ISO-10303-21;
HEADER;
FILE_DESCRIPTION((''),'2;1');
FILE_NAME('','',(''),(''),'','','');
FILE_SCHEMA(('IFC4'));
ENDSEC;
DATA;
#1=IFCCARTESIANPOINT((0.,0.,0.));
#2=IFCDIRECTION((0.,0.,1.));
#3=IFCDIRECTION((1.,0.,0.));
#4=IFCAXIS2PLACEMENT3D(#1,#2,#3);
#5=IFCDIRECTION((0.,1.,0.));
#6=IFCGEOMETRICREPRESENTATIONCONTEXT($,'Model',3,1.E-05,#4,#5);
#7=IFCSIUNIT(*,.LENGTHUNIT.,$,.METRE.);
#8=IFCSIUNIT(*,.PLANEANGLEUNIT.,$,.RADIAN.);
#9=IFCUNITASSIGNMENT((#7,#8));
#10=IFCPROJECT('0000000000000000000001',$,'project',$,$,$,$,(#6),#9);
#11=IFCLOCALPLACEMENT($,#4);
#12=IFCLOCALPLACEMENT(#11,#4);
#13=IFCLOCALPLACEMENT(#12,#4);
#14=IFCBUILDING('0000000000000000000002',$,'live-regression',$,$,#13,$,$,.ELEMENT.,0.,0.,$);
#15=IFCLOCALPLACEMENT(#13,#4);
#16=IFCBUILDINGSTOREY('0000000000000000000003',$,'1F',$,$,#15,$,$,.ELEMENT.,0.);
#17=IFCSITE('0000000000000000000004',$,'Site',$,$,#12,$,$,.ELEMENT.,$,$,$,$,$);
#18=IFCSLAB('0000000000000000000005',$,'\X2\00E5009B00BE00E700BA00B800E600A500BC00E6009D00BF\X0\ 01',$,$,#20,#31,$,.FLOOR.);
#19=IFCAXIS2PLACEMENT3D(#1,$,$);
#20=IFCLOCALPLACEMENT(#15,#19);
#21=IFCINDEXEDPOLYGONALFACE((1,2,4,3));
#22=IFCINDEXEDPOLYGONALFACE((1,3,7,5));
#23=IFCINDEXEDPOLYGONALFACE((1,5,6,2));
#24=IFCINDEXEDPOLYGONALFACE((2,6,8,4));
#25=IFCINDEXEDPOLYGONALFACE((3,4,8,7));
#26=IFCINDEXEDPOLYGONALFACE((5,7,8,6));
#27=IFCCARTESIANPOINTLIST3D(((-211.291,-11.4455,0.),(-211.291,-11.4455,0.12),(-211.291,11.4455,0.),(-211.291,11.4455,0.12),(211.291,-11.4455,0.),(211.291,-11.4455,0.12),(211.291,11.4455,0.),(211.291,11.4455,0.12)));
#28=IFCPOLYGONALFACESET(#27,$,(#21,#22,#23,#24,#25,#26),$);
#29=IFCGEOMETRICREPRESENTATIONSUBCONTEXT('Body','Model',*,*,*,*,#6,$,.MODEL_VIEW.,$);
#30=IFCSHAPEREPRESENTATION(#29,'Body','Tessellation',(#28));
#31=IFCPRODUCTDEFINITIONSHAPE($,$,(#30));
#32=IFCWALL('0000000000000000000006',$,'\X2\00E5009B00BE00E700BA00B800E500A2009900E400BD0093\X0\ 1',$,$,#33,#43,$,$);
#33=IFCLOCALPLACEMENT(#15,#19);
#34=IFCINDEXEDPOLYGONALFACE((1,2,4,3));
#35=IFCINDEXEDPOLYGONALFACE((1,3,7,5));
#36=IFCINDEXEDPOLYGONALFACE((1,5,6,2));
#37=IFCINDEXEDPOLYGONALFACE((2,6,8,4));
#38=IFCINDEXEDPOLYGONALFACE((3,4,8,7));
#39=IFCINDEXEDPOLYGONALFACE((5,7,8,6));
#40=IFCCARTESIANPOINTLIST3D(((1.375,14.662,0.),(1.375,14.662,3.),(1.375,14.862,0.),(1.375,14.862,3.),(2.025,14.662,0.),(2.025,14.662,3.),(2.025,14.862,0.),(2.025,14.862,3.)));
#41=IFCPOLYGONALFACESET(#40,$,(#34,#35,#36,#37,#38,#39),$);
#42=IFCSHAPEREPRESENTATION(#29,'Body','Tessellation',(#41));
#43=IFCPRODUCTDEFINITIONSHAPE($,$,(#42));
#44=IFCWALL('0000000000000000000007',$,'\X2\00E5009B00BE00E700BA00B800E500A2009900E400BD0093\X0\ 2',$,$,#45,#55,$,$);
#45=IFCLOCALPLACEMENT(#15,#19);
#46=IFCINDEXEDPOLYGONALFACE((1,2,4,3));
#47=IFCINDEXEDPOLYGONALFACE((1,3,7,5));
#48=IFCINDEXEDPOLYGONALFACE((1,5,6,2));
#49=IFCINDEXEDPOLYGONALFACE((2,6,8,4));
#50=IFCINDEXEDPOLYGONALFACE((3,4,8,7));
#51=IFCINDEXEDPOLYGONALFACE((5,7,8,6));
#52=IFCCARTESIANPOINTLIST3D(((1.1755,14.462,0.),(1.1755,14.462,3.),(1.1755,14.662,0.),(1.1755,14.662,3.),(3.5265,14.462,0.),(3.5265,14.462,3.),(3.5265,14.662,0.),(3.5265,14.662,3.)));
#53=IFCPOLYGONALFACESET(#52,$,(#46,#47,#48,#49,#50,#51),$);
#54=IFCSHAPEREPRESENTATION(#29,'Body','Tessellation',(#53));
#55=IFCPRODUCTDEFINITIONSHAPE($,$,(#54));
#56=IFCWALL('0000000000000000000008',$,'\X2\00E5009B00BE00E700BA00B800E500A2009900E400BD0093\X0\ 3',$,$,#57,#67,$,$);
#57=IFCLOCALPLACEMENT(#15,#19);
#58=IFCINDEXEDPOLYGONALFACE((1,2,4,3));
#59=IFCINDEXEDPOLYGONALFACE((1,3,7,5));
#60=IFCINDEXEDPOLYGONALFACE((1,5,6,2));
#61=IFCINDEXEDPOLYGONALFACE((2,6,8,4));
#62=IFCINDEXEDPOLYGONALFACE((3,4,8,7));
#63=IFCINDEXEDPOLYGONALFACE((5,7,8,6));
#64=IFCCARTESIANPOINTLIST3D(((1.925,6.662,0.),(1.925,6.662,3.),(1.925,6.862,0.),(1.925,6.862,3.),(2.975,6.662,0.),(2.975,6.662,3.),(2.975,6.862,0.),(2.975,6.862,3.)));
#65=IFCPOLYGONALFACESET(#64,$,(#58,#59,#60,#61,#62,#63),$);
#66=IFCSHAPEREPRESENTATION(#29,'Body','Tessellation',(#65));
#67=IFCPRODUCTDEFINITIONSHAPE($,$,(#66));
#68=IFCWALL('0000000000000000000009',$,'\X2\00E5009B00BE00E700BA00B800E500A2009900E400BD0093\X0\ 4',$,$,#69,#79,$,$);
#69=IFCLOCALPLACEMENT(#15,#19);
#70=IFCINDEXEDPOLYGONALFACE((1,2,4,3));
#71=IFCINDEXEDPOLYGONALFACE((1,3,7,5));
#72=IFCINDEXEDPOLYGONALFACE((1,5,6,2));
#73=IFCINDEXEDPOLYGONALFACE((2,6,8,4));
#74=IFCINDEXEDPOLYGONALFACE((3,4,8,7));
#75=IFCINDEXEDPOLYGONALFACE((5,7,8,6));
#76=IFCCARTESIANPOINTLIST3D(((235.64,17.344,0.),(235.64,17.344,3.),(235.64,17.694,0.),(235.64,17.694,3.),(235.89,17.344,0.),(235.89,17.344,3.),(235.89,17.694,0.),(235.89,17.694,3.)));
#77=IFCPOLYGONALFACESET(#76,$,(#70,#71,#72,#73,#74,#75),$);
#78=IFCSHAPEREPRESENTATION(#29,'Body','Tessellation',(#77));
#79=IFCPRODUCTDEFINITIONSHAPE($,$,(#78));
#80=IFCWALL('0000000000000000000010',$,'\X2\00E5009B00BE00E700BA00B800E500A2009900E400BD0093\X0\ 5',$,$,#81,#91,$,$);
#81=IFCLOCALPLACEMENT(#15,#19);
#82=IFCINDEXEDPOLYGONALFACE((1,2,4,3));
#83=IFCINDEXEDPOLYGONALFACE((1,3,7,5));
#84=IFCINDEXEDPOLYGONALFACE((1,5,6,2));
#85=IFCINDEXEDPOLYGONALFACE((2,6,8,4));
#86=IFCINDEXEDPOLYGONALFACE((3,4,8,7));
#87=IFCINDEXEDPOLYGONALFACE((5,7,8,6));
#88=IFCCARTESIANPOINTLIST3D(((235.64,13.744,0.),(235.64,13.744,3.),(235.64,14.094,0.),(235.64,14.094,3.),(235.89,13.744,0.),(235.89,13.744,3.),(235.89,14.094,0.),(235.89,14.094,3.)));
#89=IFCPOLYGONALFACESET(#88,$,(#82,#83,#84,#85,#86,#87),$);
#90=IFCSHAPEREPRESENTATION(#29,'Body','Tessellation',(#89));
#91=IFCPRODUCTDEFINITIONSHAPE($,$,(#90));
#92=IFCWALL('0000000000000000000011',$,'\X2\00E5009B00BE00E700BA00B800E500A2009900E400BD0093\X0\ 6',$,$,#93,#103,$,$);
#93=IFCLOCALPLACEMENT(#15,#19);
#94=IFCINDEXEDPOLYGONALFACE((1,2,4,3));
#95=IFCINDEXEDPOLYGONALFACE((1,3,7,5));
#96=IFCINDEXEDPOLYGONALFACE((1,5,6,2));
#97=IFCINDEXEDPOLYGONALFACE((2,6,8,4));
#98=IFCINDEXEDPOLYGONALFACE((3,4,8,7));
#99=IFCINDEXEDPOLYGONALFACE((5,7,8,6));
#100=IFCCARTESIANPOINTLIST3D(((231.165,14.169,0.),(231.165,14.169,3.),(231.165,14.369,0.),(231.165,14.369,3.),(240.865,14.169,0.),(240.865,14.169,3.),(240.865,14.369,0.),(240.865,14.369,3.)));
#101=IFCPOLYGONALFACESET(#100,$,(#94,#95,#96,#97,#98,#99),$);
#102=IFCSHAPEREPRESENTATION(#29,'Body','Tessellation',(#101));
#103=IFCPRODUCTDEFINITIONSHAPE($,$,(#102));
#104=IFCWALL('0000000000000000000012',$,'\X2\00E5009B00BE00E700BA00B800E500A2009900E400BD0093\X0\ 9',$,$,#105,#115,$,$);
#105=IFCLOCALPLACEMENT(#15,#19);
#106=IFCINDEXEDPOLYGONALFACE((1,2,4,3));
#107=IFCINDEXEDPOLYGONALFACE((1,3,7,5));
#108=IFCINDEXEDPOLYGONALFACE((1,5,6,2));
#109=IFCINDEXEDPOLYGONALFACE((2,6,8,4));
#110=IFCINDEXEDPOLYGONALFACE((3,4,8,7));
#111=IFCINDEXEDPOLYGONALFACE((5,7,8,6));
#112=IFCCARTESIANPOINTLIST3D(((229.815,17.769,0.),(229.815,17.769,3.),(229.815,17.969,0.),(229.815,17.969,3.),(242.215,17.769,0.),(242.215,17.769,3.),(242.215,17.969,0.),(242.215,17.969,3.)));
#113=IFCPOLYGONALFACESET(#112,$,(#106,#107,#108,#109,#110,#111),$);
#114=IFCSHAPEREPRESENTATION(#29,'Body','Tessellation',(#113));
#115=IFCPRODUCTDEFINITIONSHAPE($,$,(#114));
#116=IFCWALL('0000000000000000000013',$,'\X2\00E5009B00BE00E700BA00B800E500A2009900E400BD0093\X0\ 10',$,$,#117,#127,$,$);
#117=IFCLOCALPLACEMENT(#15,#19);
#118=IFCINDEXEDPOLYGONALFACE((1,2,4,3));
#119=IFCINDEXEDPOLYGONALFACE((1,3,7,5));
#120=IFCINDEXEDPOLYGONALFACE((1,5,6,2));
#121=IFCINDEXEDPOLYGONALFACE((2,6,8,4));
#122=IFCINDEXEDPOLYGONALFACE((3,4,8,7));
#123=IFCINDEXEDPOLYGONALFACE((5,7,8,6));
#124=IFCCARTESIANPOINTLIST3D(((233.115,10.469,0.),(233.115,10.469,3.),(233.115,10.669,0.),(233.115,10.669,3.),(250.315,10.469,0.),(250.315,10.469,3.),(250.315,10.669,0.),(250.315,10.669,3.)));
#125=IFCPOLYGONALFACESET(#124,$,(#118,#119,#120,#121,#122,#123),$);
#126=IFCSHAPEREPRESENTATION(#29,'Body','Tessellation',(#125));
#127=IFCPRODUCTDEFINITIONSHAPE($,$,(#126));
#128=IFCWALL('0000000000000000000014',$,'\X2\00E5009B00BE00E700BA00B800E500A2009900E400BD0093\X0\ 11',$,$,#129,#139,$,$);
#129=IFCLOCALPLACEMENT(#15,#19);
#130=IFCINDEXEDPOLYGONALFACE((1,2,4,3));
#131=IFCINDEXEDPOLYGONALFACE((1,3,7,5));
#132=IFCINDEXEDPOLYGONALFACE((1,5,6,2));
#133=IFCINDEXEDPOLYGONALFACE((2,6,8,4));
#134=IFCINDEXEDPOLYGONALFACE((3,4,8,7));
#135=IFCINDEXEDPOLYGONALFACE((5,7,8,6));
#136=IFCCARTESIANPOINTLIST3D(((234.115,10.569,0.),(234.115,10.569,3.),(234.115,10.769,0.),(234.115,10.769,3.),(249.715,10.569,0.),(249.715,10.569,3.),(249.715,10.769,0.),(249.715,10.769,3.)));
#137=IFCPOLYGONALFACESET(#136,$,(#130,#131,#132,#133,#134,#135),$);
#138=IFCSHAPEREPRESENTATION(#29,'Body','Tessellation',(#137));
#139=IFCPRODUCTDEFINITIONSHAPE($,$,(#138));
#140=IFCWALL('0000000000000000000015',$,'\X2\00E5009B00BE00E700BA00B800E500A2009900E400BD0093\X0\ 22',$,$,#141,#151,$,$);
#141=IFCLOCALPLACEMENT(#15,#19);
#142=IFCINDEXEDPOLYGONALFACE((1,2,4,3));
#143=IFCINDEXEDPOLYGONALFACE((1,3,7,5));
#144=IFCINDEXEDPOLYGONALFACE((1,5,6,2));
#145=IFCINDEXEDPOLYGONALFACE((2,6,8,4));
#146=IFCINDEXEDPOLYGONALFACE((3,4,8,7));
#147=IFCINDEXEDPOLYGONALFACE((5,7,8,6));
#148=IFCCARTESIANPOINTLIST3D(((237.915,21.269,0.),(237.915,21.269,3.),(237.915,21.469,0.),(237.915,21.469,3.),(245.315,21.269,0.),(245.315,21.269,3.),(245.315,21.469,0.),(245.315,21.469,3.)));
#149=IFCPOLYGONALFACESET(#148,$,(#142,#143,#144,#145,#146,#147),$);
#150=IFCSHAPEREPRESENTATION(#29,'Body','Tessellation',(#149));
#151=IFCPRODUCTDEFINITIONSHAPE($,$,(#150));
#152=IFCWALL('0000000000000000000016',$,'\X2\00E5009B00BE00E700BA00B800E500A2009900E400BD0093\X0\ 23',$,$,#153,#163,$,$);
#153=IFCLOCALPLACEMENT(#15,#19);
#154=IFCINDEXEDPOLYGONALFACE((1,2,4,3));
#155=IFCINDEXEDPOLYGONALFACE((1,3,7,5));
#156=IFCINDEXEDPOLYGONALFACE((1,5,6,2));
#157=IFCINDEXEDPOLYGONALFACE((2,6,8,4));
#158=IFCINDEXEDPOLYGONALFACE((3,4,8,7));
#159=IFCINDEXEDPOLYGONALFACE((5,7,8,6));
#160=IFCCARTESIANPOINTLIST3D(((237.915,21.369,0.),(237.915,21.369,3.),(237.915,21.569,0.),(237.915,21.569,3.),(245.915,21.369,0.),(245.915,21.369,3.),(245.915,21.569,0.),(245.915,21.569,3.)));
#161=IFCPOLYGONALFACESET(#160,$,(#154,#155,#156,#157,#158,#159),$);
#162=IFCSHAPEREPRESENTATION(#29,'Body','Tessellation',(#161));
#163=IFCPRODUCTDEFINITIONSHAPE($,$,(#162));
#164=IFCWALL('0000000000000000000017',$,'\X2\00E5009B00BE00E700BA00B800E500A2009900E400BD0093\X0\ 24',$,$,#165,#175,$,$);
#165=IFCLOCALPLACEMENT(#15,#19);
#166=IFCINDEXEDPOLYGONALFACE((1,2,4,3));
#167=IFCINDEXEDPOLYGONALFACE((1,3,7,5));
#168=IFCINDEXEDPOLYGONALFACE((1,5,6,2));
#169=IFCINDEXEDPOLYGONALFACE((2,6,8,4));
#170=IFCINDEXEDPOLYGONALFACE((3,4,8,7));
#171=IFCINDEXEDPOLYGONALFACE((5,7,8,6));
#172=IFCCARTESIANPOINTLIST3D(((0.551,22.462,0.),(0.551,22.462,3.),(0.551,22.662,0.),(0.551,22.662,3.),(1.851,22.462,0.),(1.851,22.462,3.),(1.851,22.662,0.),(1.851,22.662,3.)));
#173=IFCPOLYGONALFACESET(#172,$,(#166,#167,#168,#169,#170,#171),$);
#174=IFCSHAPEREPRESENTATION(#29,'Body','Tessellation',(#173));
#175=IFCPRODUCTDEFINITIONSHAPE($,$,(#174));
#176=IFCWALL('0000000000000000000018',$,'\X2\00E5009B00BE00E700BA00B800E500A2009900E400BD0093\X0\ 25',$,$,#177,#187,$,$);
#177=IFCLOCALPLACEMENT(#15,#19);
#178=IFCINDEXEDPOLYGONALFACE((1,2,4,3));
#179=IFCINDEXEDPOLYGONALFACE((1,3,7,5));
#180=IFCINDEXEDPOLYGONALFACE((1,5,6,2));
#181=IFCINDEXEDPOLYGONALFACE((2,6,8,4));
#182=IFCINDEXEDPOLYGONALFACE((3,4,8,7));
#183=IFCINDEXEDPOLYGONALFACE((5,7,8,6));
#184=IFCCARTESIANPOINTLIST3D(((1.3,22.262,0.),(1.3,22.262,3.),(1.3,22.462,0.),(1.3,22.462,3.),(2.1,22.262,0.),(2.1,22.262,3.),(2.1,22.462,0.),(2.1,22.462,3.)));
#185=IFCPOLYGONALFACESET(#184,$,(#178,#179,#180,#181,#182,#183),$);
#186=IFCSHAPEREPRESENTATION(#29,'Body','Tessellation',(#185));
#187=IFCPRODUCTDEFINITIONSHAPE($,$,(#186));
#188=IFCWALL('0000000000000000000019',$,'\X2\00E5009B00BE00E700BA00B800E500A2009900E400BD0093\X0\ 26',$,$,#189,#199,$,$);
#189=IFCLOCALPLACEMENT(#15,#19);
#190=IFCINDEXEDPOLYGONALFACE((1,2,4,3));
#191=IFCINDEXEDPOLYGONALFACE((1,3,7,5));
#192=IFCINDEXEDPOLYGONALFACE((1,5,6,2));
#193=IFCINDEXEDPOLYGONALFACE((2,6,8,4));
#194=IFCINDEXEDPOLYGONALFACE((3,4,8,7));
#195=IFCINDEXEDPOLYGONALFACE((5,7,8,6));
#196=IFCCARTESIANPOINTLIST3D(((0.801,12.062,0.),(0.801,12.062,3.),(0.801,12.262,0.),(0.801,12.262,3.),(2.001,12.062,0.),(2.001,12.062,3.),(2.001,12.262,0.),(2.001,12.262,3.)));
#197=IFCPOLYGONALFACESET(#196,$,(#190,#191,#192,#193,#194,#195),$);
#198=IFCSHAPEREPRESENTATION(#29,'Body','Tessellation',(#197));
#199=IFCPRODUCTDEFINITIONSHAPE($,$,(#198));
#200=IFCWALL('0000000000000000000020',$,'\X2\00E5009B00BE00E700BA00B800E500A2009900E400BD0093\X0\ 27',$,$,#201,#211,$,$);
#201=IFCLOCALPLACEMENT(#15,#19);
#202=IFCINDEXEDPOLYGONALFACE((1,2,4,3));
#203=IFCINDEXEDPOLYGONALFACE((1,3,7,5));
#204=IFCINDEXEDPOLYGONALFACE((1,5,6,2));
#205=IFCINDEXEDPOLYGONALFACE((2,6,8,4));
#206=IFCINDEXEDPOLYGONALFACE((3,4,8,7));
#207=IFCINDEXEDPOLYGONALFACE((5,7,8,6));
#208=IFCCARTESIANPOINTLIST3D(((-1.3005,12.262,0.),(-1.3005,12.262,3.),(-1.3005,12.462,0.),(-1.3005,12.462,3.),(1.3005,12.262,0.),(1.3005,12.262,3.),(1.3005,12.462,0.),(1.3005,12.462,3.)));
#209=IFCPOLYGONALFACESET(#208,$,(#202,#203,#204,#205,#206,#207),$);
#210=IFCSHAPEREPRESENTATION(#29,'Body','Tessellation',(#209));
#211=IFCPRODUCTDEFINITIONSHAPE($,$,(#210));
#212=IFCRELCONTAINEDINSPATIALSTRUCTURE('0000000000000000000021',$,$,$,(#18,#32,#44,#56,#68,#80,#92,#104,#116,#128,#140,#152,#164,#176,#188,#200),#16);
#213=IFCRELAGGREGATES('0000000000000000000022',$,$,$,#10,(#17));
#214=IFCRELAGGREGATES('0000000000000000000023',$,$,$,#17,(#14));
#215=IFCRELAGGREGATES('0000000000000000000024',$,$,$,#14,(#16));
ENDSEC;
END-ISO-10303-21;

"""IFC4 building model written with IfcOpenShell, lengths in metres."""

from ifc_helpers import new_model, si_unit, direction, frame, frame_2d, origin_with_axes, place, context, subcontext, project, spatial, rectangle, extrude, element, save


model = new_model("IFC4")

# Units and contexts
model_context = context("Model", 3, precision=1e-05, world=origin_with_axes(), true_north=direction((0.0, 1.0, 0.0)))
body_context = subcontext(model_context, "Body", "Model", "MODEL_VIEW")
ifc_project = project(units=[si_unit("LENGTHUNIT", "METRE"), si_unit("PLANEANGLEUNIT", "RADIAN")], contexts=[model_context])

# Site, building, storey
placement = place(None, origin_with_axes())
site_placement = place(placement, origin_with_axes())
site = spatial("IfcSite", under=ifc_project, at=site_placement, Name="Site", CompositionType="ELEMENT")
building_placement = place(site_placement, origin_with_axes())
building = spatial("IfcBuilding", under=site, at=building_placement, Name="live-regression", CompositionType="ELEMENT", ElevationOfRefHeight=0.0, ElevationOfTerrain=0.0)
storey_placement = place(building_placement, origin_with_axes())
storey = spatial("IfcBuildingStorey", under=building, at=storey_placement, Name="1F", CompositionType="ELEMENT", Elevation=0.0)

# Slab
slab_placement = place(storey_placement, origin_with_axes())
element("IfcSlab", 1, at=slab_placement, inside=storey, Name="å\u009b¾çº¸æ¥¼æ\u009d¿ 01", PredefinedType="FLOOR", context=body_context, shape_type="SweptSolid", body=[
    extrude(rectangle(XDim=422.582, YDim=22.891, at=frame_2d((0.0, 0.0), x_axis=(1.0, 0.0, 0.0))), frame((0.0, 0.0, 0.0), z_axis=(0.0, 0.0, 1.0)), (0.0, 0.0, 1.0), 0.12),
])

# Walls
wall_1_placement = place(storey_placement, frame((1.7, 14.762, 0.0), z_axis=(0.0, 0.0, 1.0), x_axis=(1.0, 0.0, 0.0)))
element("IfcWall", 2, at=wall_1_placement, inside=storey, Name="å\u009b¾çº¸å¢\u0099ä½\u0093 1", context=body_context, shape_type="SweptSolid", body=[
    extrude(rectangle(XDim=0.65, YDim=0.2, at=frame_2d((0.0, 0.0), x_axis=(1.0, 0.0, 0.0))), frame((0.0, 0.0, 0.0), z_axis=(0.0, 0.0, 1.0)), (0.0, 0.0, 1.0), 3.0),
])
wall_2_placement = place(storey_placement, frame((2.351, 14.562, 0.0), z_axis=(0.0, 0.0, 1.0), x_axis=(-1.0, 0.0, 0.0)))
element("IfcWall", 3, at=wall_2_placement, inside=storey, Name="å\u009b¾çº¸å¢\u0099ä½\u0093 2", context=body_context, shape_type="SweptSolid", body=[
    extrude(rectangle(XDim=2.351, YDim=0.2, at=frame_2d((0.0, 0.0), x_axis=(1.0, 0.0, 0.0))), frame((0.0, 0.0, 0.0), z_axis=(0.0, 0.0, 1.0)), (0.0, 0.0, 1.0), 3.0),
])
wall_3_placement = place(storey_placement, frame((2.45, 6.762, 0.0), z_axis=(0.0, 0.0, 1.0), x_axis=(-1.0, 0.0, 0.0)))
element("IfcWall", 4, at=wall_3_placement, inside=storey, Name="å\u009b¾çº¸å¢\u0099ä½\u0093 3", context=body_context, shape_type="SweptSolid", body=[
    extrude(rectangle(XDim=1.05, YDim=0.2, at=frame_2d((0.0, 0.0), x_axis=(1.0, 0.0, 0.0))), frame((0.0, 0.0, 0.0), z_axis=(0.0, 0.0, 1.0)), (0.0, 0.0, 1.0), 3.0),
])
for number, where, z_axis, x_axis, name in (
    (5, (235.765, 17.519, 0.0), (0.0, 0.0, 1.0), (1.0, 0.0, 0.0), "å\u009b¾çº¸å¢\u0099ä½\u0093 4"),
    (6, (235.765, 13.919, 0.0), (0.0, 0.0, 1.0), (1.0, 0.0, 0.0), "å\u009b¾çº¸å¢\u0099ä½\u0093 5"),
):
    element("IfcWall", number, at=place(storey_placement, frame(where, z_axis=z_axis, x_axis=x_axis)), inside=storey, Name=name, context=body_context, shape_type="SweptSolid", body=[
        extrude(rectangle(XDim=0.25, YDim=0.35, at=frame_2d((0.0, 0.0), x_axis=(1.0, 0.0, 0.0))), frame((0.0, 0.0, 0.0), z_axis=(0.0, 0.0, 1.0)), (0.0, 0.0, 1.0), 3.0),
    ])
wall_4_placement = place(storey_placement, frame((236.015, 14.269, 0.0), z_axis=(0.0, 0.0, 1.0), x_axis=(-1.0, 0.0, 0.0)))
element("IfcWall", 7, at=wall_4_placement, inside=storey, Name="å\u009b¾çº¸å¢\u0099ä½\u0093 6", context=body_context, shape_type="SweptSolid", body=[
    extrude(rectangle(XDim=9.7, YDim=0.2, at=frame_2d((0.0, 0.0), x_axis=(1.0, 0.0, 0.0))), frame((0.0, 0.0, 0.0), z_axis=(0.0, 0.0, 1.0)), (0.0, 0.0, 1.0), 3.0),
])
wall_5_placement = place(storey_placement, frame((236.015, 17.869, 0.0), z_axis=(0.0, 0.0, 1.0), x_axis=(-1.0, 0.0, 0.0)))
element("IfcWall", 8, at=wall_5_placement, inside=storey, Name="å\u009b¾çº¸å¢\u0099ä½\u0093 9", context=body_context, shape_type="SweptSolid", body=[
    extrude(rectangle(XDim=12.4, YDim=0.2, at=frame_2d((0.0, 0.0), x_axis=(1.0, 0.0, 0.0))), frame((0.0, 0.0, 0.0), z_axis=(0.0, 0.0, 1.0)), (0.0, 0.0, 1.0), 3.0),
])
wall_6_placement = place(storey_placement, frame((241.715, 10.569, 0.0), z_axis=(0.0, 0.0, 1.0), x_axis=(-1.0, 0.0, 0.0)))
element("IfcWall", 9, at=wall_6_placement, inside=storey, Name="å\u009b¾çº¸å¢\u0099ä½\u0093 10", context=body_context, shape_type="SweptSolid", body=[
    extrude(rectangle(XDim=17.2, YDim=0.2, at=frame_2d((0.0, 0.0), x_axis=(1.0, 0.0, 0.0))), frame((0.0, 0.0, 0.0), z_axis=(0.0, 0.0, 1.0)), (0.0, 0.0, 1.0), 3.0),
])
wall_7_placement = place(storey_placement, frame((241.915, 10.669, 0.0), z_axis=(0.0, 0.0, 1.0), x_axis=(-1.0, 0.0, 0.0)))
element("IfcWall", 10, at=wall_7_placement, inside=storey, Name="å\u009b¾çº¸å¢\u0099ä½\u0093 11", context=body_context, shape_type="SweptSolid", body=[
    extrude(rectangle(XDim=15.6, YDim=0.2, at=frame_2d((0.0, 0.0), x_axis=(1.0, 0.0, 0.0))), frame((0.0, 0.0, 0.0), z_axis=(0.0, 0.0, 1.0)), (0.0, 0.0, 1.0), 3.0),
])
wall_8_placement = place(storey_placement, frame((241.615, 21.369, 0.0), z_axis=(0.0, 0.0, 1.0), x_axis=(-1.0, 0.0, 0.0)))
element("IfcWall", 11, at=wall_8_placement, inside=storey, Name="å\u009b¾çº¸å¢\u0099ä½\u0093 22", context=body_context, shape_type="SweptSolid", body=[
    extrude(rectangle(XDim=7.4, YDim=0.2, at=frame_2d((0.0, 0.0), x_axis=(1.0, 0.0, 0.0))), frame((0.0, 0.0, 0.0), z_axis=(0.0, 0.0, 1.0)), (0.0, 0.0, 1.0), 3.0),
])
wall_9_placement = place(storey_placement, frame((241.915, 21.469, 0.0), z_axis=(0.0, 0.0, 1.0), x_axis=(-1.0, 0.0, 0.0)))
element("IfcWall", 12, at=wall_9_placement, inside=storey, Name="å\u009b¾çº¸å¢\u0099ä½\u0093 23", context=body_context, shape_type="SweptSolid", body=[
    extrude(rectangle(XDim=8.0, YDim=0.2, at=frame_2d((0.0, 0.0), x_axis=(1.0, 0.0, 0.0))), frame((0.0, 0.0, 0.0), z_axis=(0.0, 0.0, 1.0)), (0.0, 0.0, 1.0), 3.0),
])
wall_10_placement = place(storey_placement, frame((1.201, 22.562, 0.0), z_axis=(0.0, 0.0, 1.0), x_axis=(1.0, 0.0, 0.0)))
element("IfcWall", 13, at=wall_10_placement, inside=storey, Name="å\u009b¾çº¸å¢\u0099ä½\u0093 24", context=body_context, shape_type="SweptSolid", body=[
    extrude(rectangle(XDim=1.3, YDim=0.2, at=frame_2d((0.0, 0.0), x_axis=(1.0, 0.0, 0.0))), frame((0.0, 0.0, 0.0), z_axis=(0.0, 0.0, 1.0)), (0.0, 0.0, 1.0), 3.0),
])
wall_11_placement = place(storey_placement, frame((1.7, 22.362, 0.0), z_axis=(0.0, 0.0, 1.0), x_axis=(1.0, 0.0, 0.0)))
element("IfcWall", 14, at=wall_11_placement, inside=storey, Name="å\u009b¾çº¸å¢\u0099ä½\u0093 25", context=body_context, shape_type="SweptSolid", body=[
    extrude(rectangle(XDim=0.8, YDim=0.2, at=frame_2d((0.0, 0.0), x_axis=(1.0, 0.0, 0.0))), frame((0.0, 0.0, 0.0), z_axis=(0.0, 0.0, 1.0)), (0.0, 0.0, 1.0), 3.0),
])
wall_12_placement = place(storey_placement, frame((1.401, 12.162, 0.0), z_axis=(0.0, 0.0, 1.0), x_axis=(1.0, 0.0, 0.0)))
element("IfcWall", 15, at=wall_12_placement, inside=storey, Name="å\u009b¾çº¸å¢\u0099ä½\u0093 26", context=body_context, shape_type="SweptSolid", body=[
    extrude(rectangle(XDim=1.2, YDim=0.2, at=frame_2d((0.0, 0.0), x_axis=(1.0, 0.0, 0.0))), frame((0.0, 0.0, 0.0), z_axis=(0.0, 0.0, 1.0)), (0.0, 0.0, 1.0), 3.0),
])
wall_13_placement = place(storey_placement, frame((0.0, 12.362, 0.0), z_axis=(0.0, 0.0, 1.0), x_axis=(1.0, 0.0, 0.0)))
element("IfcWall", 16, at=wall_13_placement, inside=storey, Name="å\u009b¾çº¸å¢\u0099ä½\u0093 27", context=body_context, shape_type="SweptSolid", body=[
    extrude(rectangle(XDim=2.601, YDim=0.2, at=frame_2d((0.0, 0.0), x_axis=(1.0, 0.0, 0.0))), frame((0.0, 0.0, 0.0), z_axis=(0.0, 0.0, 1.0)), (0.0, 0.0, 1.0), 3.0),
])

save(model, "model.ifc")
